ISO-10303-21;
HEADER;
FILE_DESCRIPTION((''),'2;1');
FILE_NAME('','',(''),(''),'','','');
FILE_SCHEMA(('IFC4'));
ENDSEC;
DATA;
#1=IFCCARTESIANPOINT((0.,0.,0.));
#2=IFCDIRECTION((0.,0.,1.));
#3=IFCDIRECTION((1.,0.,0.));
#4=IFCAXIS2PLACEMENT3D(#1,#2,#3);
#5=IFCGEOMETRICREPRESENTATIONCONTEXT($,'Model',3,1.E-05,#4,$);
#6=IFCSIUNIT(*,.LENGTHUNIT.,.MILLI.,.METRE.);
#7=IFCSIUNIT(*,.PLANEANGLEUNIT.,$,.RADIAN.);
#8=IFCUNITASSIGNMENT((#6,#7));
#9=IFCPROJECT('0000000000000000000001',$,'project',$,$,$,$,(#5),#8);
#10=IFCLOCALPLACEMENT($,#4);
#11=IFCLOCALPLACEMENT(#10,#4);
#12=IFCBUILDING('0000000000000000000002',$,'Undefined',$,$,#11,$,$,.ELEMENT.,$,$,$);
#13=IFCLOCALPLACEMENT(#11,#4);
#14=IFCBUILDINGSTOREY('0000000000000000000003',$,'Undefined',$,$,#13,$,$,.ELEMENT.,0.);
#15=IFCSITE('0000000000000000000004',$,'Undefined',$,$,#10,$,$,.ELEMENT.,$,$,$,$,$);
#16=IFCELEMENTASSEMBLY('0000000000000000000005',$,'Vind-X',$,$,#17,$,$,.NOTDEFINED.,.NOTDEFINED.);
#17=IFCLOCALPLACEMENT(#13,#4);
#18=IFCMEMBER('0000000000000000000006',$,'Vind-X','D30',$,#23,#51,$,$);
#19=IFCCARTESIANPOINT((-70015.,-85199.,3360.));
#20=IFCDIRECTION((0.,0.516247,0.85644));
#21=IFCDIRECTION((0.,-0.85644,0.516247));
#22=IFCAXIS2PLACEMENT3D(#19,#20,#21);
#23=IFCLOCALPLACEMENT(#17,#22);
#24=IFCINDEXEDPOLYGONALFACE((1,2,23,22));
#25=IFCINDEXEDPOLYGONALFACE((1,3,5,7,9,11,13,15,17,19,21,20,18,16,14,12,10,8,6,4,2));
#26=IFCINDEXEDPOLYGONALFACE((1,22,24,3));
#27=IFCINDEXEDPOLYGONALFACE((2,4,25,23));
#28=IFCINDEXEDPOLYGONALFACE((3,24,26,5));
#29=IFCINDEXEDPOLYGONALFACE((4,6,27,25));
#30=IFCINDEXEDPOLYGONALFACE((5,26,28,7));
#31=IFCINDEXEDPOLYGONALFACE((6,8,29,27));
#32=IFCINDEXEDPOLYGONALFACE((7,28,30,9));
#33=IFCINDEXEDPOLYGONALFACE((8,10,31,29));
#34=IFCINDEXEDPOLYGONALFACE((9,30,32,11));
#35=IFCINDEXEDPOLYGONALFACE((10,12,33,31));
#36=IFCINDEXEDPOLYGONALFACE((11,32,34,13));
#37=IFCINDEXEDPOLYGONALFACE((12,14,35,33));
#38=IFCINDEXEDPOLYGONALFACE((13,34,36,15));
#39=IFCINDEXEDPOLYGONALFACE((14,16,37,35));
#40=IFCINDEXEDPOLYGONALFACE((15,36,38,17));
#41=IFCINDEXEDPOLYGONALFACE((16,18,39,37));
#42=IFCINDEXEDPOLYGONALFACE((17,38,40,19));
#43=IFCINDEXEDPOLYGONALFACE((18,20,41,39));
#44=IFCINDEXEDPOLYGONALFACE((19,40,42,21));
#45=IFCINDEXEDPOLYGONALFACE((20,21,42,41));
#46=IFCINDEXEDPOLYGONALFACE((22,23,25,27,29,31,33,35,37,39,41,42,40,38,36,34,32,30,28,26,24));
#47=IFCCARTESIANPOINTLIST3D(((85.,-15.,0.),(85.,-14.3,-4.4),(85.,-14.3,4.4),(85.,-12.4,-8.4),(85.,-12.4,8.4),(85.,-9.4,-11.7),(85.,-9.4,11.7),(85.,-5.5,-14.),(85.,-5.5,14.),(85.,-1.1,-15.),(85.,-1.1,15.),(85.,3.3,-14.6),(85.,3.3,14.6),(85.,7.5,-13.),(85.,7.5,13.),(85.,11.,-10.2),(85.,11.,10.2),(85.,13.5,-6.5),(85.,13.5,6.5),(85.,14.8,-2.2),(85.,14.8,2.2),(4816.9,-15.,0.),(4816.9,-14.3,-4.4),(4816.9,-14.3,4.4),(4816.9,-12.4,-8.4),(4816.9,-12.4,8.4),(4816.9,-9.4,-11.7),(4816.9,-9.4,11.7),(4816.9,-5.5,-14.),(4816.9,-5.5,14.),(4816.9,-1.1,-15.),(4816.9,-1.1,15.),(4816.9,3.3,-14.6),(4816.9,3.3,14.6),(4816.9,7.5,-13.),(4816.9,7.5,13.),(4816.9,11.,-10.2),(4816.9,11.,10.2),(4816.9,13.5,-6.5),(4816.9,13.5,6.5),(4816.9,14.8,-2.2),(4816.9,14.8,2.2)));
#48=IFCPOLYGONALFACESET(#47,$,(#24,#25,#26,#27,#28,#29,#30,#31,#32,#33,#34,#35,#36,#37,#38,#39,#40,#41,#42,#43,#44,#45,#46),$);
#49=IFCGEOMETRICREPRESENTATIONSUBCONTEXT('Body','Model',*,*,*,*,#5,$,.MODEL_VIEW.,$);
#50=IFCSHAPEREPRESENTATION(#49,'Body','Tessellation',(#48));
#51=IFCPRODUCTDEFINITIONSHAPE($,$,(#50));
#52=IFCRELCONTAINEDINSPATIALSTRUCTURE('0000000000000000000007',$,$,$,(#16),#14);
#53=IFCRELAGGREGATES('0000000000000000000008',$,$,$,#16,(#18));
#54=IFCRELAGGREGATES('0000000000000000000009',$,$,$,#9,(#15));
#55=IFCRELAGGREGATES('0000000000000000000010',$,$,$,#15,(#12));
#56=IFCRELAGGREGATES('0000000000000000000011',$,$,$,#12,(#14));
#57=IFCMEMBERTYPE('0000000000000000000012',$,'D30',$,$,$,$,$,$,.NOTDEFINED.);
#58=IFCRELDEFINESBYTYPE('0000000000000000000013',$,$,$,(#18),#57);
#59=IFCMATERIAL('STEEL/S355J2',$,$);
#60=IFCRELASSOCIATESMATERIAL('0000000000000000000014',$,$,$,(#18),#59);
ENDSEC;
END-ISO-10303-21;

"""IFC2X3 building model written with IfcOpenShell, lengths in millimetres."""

from ifc_helpers import new_model, si_unit, frame, origin_with_axes, origin_2d_with_axis, place, context, subcontext, project, spatial, circle, extrude, clip, halfspace, material, type_object, element, aggregate, save


model = new_model("IFC2X3")

# Units and contexts
model_context = context("Model", 3, precision=1e-05, world=origin_with_axes())
body_context = subcontext(model_context, "Body", "Model", "MODEL_VIEW")
ifc_project = project(units=[si_unit("LENGTHUNIT", "METRE", prefix="MILLI"), si_unit("PLANEANGLEUNIT", "RADIAN")], contexts=[model_context])

# Site, building, storey
site_placement = place(None, origin_with_axes())
site = spatial("IfcSite", under=ifc_project, at=site_placement, Name="Undefined", CompositionType="ELEMENT")
building_placement = place(site_placement, origin_with_axes())
building = spatial("IfcBuilding", under=site, at=building_placement, Name="Undefined", CompositionType="ELEMENT")
storey_placement = place(building_placement, origin_with_axes())
storey = spatial("IfcBuildingStorey", under=building, at=storey_placement, Name="Undefined", CompositionType="ELEMENT", Elevation=0.0)

# Element assembly, member
assembly_1_placement = place(storey_placement, origin_with_axes())
assembly_1 = element("IfcElementAssembly", 1, at=assembly_1_placement, inside=storey, Name="Vind-X", AssemblyPlace="NOTDEFINED", PredefinedType="NOTDEFINED")
ifc_material_1 = material(Name="STEEL/S355J2")
member_type = type_object("IfcMemberType", Name="D30", PredefinedType="NOTDEFINED")
member_placement = place(assembly_1_placement, frame((-70015.0, -85199.0, 3360.0), z_axis=(0.0, 0.516247, 0.85644), x_axis=(0.0, -0.85644, 0.516247)))
member = element("IfcMember", 2, at=member_placement, type_object=member_type, material=ifc_material_1, Name="Vind-X", Description="D30", context=body_context, shape_type="Clipping", body=[
    clip(clip(extrude(circle(Radius=15.0, at=origin_2d_with_axis()), frame((5481.9, 0.0, 0.0), z_axis=(-1.0, 0.0, 0.0), x_axis=(0.0, -1.0, 0.0)), (0.0, 0.0, 1.0), 5481.9), halfspace(frame((4816.9, -6.0, 10.2), z_axis=(1.0, 0.0, 0.0), x_axis=(0.0, 1.0, 0.0)), False)), halfspace(frame((85.0, -6.0, 16.0), z_axis=(1.0, 0.0, 0.0), x_axis=(0.0, 1.0, 0.0)), True)),
])

aggregate(assembly_1, [member])

save(model, "model.ifc")
